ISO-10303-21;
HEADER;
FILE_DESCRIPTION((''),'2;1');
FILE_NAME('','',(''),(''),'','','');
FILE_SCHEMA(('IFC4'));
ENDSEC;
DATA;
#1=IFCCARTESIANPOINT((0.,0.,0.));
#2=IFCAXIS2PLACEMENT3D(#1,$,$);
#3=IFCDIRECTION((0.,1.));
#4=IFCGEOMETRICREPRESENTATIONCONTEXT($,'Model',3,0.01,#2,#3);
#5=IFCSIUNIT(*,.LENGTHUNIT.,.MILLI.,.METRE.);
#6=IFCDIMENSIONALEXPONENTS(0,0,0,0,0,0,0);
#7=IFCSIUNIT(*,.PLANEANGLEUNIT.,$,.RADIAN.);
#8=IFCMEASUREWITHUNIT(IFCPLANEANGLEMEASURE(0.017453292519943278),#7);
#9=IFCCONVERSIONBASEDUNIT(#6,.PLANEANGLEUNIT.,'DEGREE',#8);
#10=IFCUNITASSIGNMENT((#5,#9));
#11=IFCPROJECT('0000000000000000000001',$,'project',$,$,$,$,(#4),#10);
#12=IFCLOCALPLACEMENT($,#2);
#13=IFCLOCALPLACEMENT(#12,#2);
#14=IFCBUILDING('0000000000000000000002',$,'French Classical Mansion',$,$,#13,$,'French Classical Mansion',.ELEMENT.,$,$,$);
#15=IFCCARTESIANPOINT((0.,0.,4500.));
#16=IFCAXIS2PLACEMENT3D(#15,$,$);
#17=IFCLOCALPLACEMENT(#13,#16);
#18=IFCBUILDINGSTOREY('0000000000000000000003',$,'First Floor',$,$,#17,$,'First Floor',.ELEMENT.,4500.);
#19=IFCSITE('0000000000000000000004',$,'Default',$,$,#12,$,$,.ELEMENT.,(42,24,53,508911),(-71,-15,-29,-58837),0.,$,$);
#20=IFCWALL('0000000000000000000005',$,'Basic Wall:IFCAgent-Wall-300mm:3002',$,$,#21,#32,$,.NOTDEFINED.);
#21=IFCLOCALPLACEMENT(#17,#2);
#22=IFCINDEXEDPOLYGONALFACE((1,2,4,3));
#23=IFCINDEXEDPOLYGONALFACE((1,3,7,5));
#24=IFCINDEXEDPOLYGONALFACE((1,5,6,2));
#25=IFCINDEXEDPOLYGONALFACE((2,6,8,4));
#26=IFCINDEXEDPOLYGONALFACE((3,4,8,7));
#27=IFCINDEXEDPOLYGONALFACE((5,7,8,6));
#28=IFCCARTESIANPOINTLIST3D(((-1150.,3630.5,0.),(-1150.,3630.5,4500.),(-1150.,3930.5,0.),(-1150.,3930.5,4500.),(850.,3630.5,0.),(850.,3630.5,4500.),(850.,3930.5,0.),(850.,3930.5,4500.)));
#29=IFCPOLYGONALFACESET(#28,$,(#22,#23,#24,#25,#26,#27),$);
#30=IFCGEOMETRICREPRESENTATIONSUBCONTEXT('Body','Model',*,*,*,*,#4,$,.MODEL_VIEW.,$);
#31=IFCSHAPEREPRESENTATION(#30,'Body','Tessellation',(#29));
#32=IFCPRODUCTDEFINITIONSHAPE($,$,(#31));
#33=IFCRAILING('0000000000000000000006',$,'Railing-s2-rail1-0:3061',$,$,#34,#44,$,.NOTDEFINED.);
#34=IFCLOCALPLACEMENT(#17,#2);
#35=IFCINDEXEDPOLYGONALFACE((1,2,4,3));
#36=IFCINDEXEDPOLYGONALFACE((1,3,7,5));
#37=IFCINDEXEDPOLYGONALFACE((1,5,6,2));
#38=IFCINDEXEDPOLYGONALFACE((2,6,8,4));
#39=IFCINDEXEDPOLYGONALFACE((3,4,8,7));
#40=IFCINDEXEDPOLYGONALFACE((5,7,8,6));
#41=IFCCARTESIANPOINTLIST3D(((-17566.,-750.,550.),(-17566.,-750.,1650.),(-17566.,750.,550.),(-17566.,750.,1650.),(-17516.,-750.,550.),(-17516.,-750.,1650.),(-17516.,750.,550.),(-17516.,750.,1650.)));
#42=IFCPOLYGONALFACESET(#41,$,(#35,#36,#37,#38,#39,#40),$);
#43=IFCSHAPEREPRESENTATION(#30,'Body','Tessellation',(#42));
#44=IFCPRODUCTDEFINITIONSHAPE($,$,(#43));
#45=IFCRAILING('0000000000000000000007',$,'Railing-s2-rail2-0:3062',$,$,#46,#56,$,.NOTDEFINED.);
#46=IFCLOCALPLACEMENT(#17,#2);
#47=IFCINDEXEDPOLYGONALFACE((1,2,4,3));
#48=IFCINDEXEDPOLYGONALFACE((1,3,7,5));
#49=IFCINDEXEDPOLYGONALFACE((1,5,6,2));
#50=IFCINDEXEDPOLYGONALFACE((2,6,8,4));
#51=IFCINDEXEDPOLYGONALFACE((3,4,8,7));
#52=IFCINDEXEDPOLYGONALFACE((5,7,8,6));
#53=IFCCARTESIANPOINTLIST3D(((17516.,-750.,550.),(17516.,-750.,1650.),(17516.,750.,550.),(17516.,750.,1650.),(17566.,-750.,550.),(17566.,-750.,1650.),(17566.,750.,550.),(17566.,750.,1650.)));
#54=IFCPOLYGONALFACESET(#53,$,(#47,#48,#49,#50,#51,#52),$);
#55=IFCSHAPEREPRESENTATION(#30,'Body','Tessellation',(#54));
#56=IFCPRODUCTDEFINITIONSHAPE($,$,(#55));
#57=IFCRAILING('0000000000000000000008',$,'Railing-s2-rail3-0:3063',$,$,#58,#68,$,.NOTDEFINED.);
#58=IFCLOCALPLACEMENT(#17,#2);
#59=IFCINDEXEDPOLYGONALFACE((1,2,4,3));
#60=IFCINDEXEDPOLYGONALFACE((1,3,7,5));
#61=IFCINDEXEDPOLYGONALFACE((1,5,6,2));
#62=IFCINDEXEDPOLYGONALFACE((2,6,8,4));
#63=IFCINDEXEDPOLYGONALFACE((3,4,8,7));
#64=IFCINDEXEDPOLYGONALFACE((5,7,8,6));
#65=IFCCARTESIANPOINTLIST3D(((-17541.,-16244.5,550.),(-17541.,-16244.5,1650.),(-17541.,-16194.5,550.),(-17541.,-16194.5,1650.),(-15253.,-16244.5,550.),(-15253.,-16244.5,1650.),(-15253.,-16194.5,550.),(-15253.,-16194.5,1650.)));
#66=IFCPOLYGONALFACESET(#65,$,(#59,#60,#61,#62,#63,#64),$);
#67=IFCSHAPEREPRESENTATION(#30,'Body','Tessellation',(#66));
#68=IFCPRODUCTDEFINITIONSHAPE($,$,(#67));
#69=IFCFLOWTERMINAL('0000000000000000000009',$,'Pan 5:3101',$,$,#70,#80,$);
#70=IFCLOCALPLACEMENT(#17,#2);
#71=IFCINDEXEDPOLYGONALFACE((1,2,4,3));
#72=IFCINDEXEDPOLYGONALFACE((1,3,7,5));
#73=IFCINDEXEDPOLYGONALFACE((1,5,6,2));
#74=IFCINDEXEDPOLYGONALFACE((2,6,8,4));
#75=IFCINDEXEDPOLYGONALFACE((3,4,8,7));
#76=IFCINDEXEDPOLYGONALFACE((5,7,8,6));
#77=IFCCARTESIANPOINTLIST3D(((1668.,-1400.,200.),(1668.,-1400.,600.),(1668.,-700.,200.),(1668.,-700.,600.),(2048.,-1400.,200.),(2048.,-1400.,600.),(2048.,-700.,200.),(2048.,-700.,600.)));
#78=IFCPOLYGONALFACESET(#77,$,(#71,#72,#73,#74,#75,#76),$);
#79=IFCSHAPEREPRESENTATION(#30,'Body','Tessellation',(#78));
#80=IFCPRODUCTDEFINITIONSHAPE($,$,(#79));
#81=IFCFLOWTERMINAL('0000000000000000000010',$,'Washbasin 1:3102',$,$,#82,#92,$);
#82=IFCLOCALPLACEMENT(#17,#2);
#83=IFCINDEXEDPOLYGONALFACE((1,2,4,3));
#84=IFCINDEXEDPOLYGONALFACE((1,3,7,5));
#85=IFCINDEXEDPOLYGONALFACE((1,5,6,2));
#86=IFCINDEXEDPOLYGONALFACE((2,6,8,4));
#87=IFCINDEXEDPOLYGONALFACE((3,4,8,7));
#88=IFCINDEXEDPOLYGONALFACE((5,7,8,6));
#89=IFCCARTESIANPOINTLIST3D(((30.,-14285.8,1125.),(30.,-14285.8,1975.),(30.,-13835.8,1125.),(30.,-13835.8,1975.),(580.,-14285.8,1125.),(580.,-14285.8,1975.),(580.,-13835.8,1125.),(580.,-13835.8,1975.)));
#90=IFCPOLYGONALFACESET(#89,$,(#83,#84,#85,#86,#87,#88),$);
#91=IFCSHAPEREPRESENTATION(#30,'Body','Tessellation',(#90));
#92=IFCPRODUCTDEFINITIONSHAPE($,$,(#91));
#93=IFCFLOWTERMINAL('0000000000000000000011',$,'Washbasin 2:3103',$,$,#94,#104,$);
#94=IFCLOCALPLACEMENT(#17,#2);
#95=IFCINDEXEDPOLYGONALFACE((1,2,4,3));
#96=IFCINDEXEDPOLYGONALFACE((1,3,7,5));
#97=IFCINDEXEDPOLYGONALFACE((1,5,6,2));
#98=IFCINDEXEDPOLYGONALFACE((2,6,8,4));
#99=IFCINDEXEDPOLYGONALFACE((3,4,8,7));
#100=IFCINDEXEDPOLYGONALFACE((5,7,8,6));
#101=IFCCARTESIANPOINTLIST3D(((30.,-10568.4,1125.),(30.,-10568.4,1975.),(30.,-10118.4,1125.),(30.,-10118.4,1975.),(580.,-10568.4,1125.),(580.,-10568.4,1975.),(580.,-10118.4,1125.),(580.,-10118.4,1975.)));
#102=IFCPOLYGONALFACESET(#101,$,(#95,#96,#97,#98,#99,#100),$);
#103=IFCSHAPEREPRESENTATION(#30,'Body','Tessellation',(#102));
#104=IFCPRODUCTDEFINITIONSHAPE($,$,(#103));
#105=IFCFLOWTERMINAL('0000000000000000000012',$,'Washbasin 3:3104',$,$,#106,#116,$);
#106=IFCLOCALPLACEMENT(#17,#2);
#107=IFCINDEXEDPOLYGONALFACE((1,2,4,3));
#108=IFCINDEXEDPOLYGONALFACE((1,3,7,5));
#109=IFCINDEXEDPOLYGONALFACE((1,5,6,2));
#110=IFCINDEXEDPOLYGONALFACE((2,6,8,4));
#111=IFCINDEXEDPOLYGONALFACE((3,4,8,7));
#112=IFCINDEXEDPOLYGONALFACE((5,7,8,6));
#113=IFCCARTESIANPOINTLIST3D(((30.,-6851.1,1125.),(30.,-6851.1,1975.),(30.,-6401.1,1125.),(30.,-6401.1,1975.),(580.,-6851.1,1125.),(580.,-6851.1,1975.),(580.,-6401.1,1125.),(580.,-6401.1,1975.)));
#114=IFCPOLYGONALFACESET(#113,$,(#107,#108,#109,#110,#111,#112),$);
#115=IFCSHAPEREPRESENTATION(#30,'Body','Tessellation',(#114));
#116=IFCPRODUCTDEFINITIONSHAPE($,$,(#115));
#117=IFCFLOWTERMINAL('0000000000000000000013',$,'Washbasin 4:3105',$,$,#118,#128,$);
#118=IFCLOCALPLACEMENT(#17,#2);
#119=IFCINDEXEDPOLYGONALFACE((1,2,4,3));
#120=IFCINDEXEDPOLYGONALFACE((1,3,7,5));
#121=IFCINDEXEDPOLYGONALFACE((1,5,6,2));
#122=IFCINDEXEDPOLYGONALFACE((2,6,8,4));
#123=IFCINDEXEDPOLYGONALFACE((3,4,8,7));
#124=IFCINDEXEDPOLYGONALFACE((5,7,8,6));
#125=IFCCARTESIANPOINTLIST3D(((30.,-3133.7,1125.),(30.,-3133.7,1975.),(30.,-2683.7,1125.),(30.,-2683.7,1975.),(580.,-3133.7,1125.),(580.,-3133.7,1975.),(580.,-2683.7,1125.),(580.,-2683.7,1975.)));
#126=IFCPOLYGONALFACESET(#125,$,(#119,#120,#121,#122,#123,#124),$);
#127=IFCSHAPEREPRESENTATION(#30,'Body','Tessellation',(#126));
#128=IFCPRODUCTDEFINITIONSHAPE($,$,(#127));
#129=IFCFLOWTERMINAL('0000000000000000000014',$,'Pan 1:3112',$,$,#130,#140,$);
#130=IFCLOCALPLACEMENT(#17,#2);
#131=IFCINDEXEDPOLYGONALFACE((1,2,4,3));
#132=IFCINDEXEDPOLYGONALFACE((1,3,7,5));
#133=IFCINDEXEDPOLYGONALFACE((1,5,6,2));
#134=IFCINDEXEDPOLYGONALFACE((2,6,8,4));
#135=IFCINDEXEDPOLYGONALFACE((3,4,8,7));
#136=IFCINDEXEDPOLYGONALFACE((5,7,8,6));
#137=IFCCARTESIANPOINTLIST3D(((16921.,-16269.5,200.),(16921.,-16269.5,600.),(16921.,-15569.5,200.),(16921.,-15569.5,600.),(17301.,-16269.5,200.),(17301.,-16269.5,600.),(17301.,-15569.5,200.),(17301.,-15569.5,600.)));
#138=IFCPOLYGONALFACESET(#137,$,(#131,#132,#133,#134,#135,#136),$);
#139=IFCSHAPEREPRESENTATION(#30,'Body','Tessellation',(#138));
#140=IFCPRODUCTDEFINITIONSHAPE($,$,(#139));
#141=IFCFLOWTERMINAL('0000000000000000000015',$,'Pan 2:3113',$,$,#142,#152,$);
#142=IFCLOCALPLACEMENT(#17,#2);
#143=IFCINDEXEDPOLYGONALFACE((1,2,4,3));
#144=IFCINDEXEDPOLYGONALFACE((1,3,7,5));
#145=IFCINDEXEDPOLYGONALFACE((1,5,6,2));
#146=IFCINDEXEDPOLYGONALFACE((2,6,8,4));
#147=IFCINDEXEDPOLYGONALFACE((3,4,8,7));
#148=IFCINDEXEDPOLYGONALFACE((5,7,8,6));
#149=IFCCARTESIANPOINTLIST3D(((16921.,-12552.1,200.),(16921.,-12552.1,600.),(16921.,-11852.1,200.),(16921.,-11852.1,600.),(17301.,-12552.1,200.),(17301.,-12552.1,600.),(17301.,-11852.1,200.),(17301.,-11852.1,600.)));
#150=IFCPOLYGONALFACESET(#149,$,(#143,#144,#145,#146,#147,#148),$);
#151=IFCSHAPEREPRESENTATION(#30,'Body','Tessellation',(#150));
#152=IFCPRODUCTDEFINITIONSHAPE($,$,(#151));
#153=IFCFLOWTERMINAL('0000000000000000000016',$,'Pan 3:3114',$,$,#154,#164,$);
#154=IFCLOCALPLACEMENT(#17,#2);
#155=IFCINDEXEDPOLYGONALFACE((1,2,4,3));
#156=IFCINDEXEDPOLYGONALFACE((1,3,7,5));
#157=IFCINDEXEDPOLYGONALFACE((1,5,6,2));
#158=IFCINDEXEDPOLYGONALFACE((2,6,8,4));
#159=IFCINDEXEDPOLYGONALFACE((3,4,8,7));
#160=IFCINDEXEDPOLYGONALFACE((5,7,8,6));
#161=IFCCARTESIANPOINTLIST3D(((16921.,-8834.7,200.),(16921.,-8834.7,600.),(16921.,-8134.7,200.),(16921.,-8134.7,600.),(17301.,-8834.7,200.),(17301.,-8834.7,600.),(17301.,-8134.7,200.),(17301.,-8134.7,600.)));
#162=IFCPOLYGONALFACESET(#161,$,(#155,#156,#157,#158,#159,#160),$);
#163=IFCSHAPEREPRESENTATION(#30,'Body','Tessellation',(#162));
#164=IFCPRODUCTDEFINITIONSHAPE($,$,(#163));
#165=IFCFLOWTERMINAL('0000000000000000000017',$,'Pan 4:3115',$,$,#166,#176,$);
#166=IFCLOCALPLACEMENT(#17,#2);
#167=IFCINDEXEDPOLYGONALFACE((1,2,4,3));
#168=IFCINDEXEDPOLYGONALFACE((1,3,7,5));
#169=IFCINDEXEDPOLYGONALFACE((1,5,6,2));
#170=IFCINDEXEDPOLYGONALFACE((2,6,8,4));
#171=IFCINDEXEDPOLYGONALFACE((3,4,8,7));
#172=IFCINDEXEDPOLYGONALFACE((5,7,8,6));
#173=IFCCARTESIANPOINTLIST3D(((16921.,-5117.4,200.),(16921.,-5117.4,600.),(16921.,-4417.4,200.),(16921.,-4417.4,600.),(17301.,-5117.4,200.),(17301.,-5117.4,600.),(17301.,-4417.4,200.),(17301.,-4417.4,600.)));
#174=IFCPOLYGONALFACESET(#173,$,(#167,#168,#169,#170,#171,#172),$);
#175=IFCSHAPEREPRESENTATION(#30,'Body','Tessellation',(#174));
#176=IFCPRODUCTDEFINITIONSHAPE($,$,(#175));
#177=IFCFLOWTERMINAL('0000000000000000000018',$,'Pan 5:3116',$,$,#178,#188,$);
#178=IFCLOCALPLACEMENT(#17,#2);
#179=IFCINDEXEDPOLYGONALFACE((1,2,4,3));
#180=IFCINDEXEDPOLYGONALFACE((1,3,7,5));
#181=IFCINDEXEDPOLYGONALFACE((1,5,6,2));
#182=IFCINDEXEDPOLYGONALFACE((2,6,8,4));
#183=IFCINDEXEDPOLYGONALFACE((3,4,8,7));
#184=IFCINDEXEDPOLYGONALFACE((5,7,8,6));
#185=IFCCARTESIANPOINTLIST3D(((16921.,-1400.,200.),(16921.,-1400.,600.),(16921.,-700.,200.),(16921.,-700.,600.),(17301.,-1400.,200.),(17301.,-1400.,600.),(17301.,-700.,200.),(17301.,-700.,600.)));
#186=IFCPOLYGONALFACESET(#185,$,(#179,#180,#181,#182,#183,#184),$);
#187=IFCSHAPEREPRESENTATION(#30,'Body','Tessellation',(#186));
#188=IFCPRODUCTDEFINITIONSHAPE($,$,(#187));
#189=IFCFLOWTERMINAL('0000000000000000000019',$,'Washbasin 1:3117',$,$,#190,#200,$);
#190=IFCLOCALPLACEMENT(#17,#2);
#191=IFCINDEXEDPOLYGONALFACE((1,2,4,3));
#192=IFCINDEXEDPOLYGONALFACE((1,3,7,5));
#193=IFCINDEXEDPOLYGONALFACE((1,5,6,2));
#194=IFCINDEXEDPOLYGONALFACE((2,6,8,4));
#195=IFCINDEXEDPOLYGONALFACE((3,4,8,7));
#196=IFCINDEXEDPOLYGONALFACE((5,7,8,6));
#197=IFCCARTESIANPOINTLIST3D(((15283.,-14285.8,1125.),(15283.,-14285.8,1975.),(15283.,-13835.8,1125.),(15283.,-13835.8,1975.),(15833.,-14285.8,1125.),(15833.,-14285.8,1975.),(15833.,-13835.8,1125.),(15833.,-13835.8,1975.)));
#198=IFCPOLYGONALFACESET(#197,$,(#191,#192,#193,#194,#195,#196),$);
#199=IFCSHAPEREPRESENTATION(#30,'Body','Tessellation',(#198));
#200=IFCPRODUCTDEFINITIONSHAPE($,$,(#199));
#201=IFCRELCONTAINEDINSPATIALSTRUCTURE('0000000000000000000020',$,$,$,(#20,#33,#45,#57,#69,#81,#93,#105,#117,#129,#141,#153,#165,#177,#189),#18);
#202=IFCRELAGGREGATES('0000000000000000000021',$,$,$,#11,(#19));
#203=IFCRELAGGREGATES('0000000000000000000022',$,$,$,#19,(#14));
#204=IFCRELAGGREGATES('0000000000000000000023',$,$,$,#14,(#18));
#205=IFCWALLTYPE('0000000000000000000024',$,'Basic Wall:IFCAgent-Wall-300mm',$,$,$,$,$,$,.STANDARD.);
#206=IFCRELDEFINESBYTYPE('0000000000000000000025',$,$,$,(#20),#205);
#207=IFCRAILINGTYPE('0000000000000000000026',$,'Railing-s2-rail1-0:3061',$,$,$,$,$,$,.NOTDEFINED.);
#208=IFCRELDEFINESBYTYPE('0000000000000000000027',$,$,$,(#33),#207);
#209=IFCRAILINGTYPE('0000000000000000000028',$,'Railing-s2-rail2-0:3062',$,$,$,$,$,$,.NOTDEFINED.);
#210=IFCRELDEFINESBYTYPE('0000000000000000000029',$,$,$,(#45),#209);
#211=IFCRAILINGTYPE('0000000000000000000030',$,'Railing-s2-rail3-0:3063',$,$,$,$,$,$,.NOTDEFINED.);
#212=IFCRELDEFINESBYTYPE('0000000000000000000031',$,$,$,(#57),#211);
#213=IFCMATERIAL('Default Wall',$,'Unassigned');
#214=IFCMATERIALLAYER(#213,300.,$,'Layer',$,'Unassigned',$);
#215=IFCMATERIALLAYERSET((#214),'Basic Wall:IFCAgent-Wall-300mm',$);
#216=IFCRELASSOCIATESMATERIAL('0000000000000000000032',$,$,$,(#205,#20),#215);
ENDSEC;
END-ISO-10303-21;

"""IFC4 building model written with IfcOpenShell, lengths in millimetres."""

from ifc_helpers import new_model, entity, si_unit, converted_unit, direction, frame, frame_2d, origin, origin_2d_with_axis, place, context, subcontext, project, spatial, rectangle, extrude, material, layer, layer_set, layer_usage, type_object, element, save


model = new_model("IFC4")

# Units and contexts
model_context = context("Model", 3, precision=0.01, world=origin(), true_north=direction((0.0, 1.0)))
body_context = subcontext(model_context, "Body", "Model", "MODEL_VIEW")
ifc_project = project(units=[si_unit("LENGTHUNIT", "METRE", prefix="MILLI"), converted_unit("PLANEANGLEUNIT", "DEGREE", entity("IfcPlaneAngleMeasure", 0.017453292519943278), si_unit("PLANEANGLEUNIT", "RADIAN"), dimensions=[0, 0, 0, 0, 0, 0, 0])], contexts=[model_context])

# Site, building, storey
site_placement = place(None, origin())
site = spatial("IfcSite", under=ifc_project, at=site_placement, Name="Default", CompositionType="ELEMENT", RefLatitude=(42, 24, 53, 508911), RefLongitude=(-71, -15, -29, -58837), RefElevation=0.0)
building_placement = place(site_placement, origin())
building = spatial("IfcBuilding", under=site, at=building_placement, Name="French Classical Mansion", LongName="French Classical Mansion", CompositionType="ELEMENT")
storey_placement = place(building_placement, frame((0.0, 0.0, 4500.0)))
storey = spatial("IfcBuildingStorey", under=building, at=storey_placement, Name="First Floor", LongName="First Floor", CompositionType="ELEMENT", Elevation=4500.0)

# Wall
ifc_material = material(Name="Default Wall", Category="Unassigned")
ifc_layer = layer(ifc_material, 300.0, Name="Layer", Category="Unassigned")
ifc_layer_set = layer_set([ifc_layer], Name="Basic Wall:IFCAgent-Wall-300mm")
ifc_layer_usage = layer_usage(ifc_layer_set, "AXIS2", "NEGATIVE", 150.0)
wall_type = type_object("IfcWallType", Name="Basic Wall:IFCAgent-Wall-300mm", PredefinedType="STANDARD", material=ifc_layer_set)
wall_placement = place(storey_placement, frame((850.0, 3780.5, 0.0), z_axis=(0.0, 0.0, 1.0), x_axis=(-1.0, 0.0, 0.0)))
element("IfcWall", 1, at=wall_placement, inside=storey, type_object=wall_type, material=ifc_layer_usage, Name="Basic Wall:IFCAgent-Wall-300mm:3002", PredefinedType="NOTDEFINED", context=body_context, shape_type="SweptSolid", body=[
    extrude(rectangle(XDim=2000.0, YDim=300.0, at=frame_2d((1000.0, 0.0), x_axis=(-1.0, 0.0))), origin(), (0.0, 0.0, 1.0), 4500.0),
])

# Railings
railing_type_1 = type_object("IfcRailingType", Name="Railing-s2-rail1-0:3061", PredefinedType="NOTDEFINED")
railing_1_placement = place(storey_placement, origin())
element("IfcRailing", 2, at=railing_1_placement, inside=storey, type_object=railing_type_1, Name="Railing-s2-rail1-0:3061", PredefinedType="NOTDEFINED", context=body_context, shape_type="SweptSolid", body=[
    extrude(rectangle(XDim=1500.0, YDim=50.0, at=origin_2d_with_axis()), frame((-17541.0, 0.0, 550.0), z_axis=(0.0, 0.0, 1.0), x_axis=(0.0, 1.0, 0.0)), (0.0, 0.0, 1.0), 1100.0),
])
railing_type_2 = type_object("IfcRailingType", Name="Railing-s2-rail2-0:3062", PredefinedType="NOTDEFINED")
railing_2_placement = place(storey_placement, origin())
element("IfcRailing", 3, at=railing_2_placement, inside=storey, type_object=railing_type_2, Name="Railing-s2-rail2-0:3062", PredefinedType="NOTDEFINED", context=body_context, shape_type="SweptSolid", body=[
    extrude(rectangle(XDim=1500.0, YDim=50.0, at=frame_2d((0.0, 0.0), x_axis=(1.0, 0.0))), frame((17541.0, 0.0, 550.0), z_axis=(0.0, 0.0, 1.0), x_axis=(0.0, 1.0, 0.0)), (0.0, 0.0, 1.0), 1100.0),
])
railing_type_3 = type_object("IfcRailingType", Name="Railing-s2-rail3-0:3063", PredefinedType="NOTDEFINED")
railing_3_placement = place(storey_placement, origin())
element("IfcRailing", 4, at=railing_3_placement, inside=storey, type_object=railing_type_3, Name="Railing-s2-rail3-0:3063", PredefinedType="NOTDEFINED", context=body_context, shape_type="SweptSolid", body=[
    extrude(rectangle(XDim=2288.0, YDim=50.0, at=origin_2d_with_axis()), frame((-16397.0, -16219.5, 550.0)), (0.0, 0.0, 1.0), 1100.0),
])

# Flow terminals
flow_terminal_1_placement = place(storey_placement, origin())
element("IfcFlowTerminal", 5, at=flow_terminal_1_placement, inside=storey, Name="Pan 5:3101", context=body_context, shape_type="SweptSolid", body=[
    extrude(rectangle(XDim=700.0, YDim=380.0, at=frame_2d((0.0, 0.0), x_axis=(1.0, 0.0))), frame((1858.0, -1050.0, 200.0), z_axis=(0.0, 0.0, 1.0), x_axis=(0.0, 1.0, 0.0)), (0.0, 0.0, 1.0), 400.0),
])
flow_terminal_2_placement = place(storey_placement, origin())
element("IfcFlowTerminal", 6, at=flow_terminal_2_placement, inside=storey, Name="Washbasin 1:3102", context=body_context, shape_type="SweptSolid", body=[
    extrude(rectangle(XDim=450.0, YDim=550.0, at=origin_2d_with_axis()), frame((305.0, -14060.8, 1125.0), z_axis=(0.0, 0.0, 1.0), x_axis=(0.0, 1.0, 0.0)), (0.0, 0.0, 1.0), 850.0),
])
flow_terminal_3_placement = place(storey_placement, origin())
element("IfcFlowTerminal", 7, at=flow_terminal_3_placement, inside=storey, Name="Washbasin 2:3103", context=body_context, shape_type="SweptSolid", body=[
    extrude(rectangle(XDim=450.0, YDim=550.0, at=origin_2d_with_axis()), frame((305.0, -10343.4, 1125.0), z_axis=(0.0, 0.0, 1.0), x_axis=(0.0, 1.0, 0.0)), (0.0, 0.0, 1.0), 850.0),
])
flow_terminal_4_placement = place(storey_placement, origin())
element("IfcFlowTerminal", 8, at=flow_terminal_4_placement, inside=storey, Name="Washbasin 3:3104", context=body_context, shape_type="SweptSolid", body=[
    extrude(rectangle(XDim=450.0, YDim=550.0, at=origin_2d_with_axis()), frame((305.0, -6626.1, 1125.0), z_axis=(0.0, 0.0, 1.0), x_axis=(0.0, 1.0, 0.0)), (0.0, 0.0, 1.0), 850.0),
])
flow_terminal_5_placement = place(storey_placement, origin())
element("IfcFlowTerminal", 9, at=flow_terminal_5_placement, inside=storey, Name="Washbasin 4:3105", context=body_context, shape_type="SweptSolid", body=[
    extrude(rectangle(XDim=450.0, YDim=550.0, at=origin_2d_with_axis()), frame((305.0, -2908.7, 1125.0), z_axis=(0.0, 0.0, 1.0), x_axis=(0.0, 1.0, 0.0)), (0.0, 0.0, 1.0), 850.0),
])
flow_terminal_6_placement = place(storey_placement, origin())
element("IfcFlowTerminal", 10, at=flow_terminal_6_placement, inside=storey, Name="Pan 1:3112", context=body_context, shape_type="SweptSolid", body=[
    extrude(rectangle(XDim=700.0, YDim=380.0, at=origin_2d_with_axis()), frame((17111.0, -15919.5, 200.0), z_axis=(0.0, 0.0, 1.0), x_axis=(0.0, 1.0, 0.0)), (0.0, 0.0, 1.0), 400.0),
])
flow_terminal_7_placement = place(storey_placement, origin())
element("IfcFlowTerminal", 11, at=flow_terminal_7_placement, inside=storey, Name="Pan 2:3113", context=body_context, shape_type="SweptSolid", body=[
    extrude(rectangle(XDim=700.0, YDim=380.0, at=origin_2d_with_axis()), frame((17111.0, -12202.1, 200.0), z_axis=(0.0, 0.0, 1.0), x_axis=(0.0, 1.0, 0.0)), (0.0, 0.0, 1.0), 400.0),
])
flow_terminal_8_placement = place(storey_placement, origin())
element("IfcFlowTerminal", 12, at=flow_terminal_8_placement, inside=storey, Name="Pan 3:3114", context=body_context, shape_type="SweptSolid", body=[
    extrude(rectangle(XDim=700.0, YDim=380.0, at=frame_2d((0.0, 0.0), x_axis=(1.0, 0.0))), frame((17111.0, -8484.7, 200.0), z_axis=(0.0, 0.0, 1.0), x_axis=(0.0, 1.0, 0.0)), (0.0, 0.0, 1.0), 400.0),
])
flow_terminal_9_placement = place(storey_placement, origin())
element("IfcFlowTerminal", 13, at=flow_terminal_9_placement, inside=storey, Name="Pan 4:3115", context=body_context, shape_type="SweptSolid", body=[
    extrude(rectangle(XDim=700.0, YDim=380.0, at=frame_2d((0.0, 0.0), x_axis=(1.0, 0.0))), frame((17111.0, -4767.4, 200.0), z_axis=(0.0, 0.0, 1.0), x_axis=(0.0, 1.0, 0.0)), (0.0, 0.0, 1.0), 400.0),
])
flow_terminal_10_placement = place(storey_placement, origin())
element("IfcFlowTerminal", 14, at=flow_terminal_10_placement, inside=storey, Name="Pan 5:3116", context=body_context, shape_type="SweptSolid", body=[
    extrude(rectangle(XDim=700.0, YDim=380.0, at=frame_2d((0.0, 0.0), x_axis=(1.0, 0.0))), frame((17111.0, -1050.0, 200.0), z_axis=(0.0, 0.0, 1.0), x_axis=(0.0, 1.0, 0.0)), (0.0, 0.0, 1.0), 400.0),
])
flow_terminal_11_placement = place(storey_placement, origin())
element("IfcFlowTerminal", 15, at=flow_terminal_11_placement, inside=storey, Name="Washbasin 1:3117", context=body_context, shape_type="SweptSolid", body=[
    extrude(rectangle(XDim=450.0, YDim=550.0, at=origin_2d_with_axis()), frame((15558.0, -14060.8, 1125.0), z_axis=(0.0, 0.0, 1.0), x_axis=(0.0, 1.0, 0.0)), (0.0, 0.0, 1.0), 850.0),
])

save(model, "model.ifc")
